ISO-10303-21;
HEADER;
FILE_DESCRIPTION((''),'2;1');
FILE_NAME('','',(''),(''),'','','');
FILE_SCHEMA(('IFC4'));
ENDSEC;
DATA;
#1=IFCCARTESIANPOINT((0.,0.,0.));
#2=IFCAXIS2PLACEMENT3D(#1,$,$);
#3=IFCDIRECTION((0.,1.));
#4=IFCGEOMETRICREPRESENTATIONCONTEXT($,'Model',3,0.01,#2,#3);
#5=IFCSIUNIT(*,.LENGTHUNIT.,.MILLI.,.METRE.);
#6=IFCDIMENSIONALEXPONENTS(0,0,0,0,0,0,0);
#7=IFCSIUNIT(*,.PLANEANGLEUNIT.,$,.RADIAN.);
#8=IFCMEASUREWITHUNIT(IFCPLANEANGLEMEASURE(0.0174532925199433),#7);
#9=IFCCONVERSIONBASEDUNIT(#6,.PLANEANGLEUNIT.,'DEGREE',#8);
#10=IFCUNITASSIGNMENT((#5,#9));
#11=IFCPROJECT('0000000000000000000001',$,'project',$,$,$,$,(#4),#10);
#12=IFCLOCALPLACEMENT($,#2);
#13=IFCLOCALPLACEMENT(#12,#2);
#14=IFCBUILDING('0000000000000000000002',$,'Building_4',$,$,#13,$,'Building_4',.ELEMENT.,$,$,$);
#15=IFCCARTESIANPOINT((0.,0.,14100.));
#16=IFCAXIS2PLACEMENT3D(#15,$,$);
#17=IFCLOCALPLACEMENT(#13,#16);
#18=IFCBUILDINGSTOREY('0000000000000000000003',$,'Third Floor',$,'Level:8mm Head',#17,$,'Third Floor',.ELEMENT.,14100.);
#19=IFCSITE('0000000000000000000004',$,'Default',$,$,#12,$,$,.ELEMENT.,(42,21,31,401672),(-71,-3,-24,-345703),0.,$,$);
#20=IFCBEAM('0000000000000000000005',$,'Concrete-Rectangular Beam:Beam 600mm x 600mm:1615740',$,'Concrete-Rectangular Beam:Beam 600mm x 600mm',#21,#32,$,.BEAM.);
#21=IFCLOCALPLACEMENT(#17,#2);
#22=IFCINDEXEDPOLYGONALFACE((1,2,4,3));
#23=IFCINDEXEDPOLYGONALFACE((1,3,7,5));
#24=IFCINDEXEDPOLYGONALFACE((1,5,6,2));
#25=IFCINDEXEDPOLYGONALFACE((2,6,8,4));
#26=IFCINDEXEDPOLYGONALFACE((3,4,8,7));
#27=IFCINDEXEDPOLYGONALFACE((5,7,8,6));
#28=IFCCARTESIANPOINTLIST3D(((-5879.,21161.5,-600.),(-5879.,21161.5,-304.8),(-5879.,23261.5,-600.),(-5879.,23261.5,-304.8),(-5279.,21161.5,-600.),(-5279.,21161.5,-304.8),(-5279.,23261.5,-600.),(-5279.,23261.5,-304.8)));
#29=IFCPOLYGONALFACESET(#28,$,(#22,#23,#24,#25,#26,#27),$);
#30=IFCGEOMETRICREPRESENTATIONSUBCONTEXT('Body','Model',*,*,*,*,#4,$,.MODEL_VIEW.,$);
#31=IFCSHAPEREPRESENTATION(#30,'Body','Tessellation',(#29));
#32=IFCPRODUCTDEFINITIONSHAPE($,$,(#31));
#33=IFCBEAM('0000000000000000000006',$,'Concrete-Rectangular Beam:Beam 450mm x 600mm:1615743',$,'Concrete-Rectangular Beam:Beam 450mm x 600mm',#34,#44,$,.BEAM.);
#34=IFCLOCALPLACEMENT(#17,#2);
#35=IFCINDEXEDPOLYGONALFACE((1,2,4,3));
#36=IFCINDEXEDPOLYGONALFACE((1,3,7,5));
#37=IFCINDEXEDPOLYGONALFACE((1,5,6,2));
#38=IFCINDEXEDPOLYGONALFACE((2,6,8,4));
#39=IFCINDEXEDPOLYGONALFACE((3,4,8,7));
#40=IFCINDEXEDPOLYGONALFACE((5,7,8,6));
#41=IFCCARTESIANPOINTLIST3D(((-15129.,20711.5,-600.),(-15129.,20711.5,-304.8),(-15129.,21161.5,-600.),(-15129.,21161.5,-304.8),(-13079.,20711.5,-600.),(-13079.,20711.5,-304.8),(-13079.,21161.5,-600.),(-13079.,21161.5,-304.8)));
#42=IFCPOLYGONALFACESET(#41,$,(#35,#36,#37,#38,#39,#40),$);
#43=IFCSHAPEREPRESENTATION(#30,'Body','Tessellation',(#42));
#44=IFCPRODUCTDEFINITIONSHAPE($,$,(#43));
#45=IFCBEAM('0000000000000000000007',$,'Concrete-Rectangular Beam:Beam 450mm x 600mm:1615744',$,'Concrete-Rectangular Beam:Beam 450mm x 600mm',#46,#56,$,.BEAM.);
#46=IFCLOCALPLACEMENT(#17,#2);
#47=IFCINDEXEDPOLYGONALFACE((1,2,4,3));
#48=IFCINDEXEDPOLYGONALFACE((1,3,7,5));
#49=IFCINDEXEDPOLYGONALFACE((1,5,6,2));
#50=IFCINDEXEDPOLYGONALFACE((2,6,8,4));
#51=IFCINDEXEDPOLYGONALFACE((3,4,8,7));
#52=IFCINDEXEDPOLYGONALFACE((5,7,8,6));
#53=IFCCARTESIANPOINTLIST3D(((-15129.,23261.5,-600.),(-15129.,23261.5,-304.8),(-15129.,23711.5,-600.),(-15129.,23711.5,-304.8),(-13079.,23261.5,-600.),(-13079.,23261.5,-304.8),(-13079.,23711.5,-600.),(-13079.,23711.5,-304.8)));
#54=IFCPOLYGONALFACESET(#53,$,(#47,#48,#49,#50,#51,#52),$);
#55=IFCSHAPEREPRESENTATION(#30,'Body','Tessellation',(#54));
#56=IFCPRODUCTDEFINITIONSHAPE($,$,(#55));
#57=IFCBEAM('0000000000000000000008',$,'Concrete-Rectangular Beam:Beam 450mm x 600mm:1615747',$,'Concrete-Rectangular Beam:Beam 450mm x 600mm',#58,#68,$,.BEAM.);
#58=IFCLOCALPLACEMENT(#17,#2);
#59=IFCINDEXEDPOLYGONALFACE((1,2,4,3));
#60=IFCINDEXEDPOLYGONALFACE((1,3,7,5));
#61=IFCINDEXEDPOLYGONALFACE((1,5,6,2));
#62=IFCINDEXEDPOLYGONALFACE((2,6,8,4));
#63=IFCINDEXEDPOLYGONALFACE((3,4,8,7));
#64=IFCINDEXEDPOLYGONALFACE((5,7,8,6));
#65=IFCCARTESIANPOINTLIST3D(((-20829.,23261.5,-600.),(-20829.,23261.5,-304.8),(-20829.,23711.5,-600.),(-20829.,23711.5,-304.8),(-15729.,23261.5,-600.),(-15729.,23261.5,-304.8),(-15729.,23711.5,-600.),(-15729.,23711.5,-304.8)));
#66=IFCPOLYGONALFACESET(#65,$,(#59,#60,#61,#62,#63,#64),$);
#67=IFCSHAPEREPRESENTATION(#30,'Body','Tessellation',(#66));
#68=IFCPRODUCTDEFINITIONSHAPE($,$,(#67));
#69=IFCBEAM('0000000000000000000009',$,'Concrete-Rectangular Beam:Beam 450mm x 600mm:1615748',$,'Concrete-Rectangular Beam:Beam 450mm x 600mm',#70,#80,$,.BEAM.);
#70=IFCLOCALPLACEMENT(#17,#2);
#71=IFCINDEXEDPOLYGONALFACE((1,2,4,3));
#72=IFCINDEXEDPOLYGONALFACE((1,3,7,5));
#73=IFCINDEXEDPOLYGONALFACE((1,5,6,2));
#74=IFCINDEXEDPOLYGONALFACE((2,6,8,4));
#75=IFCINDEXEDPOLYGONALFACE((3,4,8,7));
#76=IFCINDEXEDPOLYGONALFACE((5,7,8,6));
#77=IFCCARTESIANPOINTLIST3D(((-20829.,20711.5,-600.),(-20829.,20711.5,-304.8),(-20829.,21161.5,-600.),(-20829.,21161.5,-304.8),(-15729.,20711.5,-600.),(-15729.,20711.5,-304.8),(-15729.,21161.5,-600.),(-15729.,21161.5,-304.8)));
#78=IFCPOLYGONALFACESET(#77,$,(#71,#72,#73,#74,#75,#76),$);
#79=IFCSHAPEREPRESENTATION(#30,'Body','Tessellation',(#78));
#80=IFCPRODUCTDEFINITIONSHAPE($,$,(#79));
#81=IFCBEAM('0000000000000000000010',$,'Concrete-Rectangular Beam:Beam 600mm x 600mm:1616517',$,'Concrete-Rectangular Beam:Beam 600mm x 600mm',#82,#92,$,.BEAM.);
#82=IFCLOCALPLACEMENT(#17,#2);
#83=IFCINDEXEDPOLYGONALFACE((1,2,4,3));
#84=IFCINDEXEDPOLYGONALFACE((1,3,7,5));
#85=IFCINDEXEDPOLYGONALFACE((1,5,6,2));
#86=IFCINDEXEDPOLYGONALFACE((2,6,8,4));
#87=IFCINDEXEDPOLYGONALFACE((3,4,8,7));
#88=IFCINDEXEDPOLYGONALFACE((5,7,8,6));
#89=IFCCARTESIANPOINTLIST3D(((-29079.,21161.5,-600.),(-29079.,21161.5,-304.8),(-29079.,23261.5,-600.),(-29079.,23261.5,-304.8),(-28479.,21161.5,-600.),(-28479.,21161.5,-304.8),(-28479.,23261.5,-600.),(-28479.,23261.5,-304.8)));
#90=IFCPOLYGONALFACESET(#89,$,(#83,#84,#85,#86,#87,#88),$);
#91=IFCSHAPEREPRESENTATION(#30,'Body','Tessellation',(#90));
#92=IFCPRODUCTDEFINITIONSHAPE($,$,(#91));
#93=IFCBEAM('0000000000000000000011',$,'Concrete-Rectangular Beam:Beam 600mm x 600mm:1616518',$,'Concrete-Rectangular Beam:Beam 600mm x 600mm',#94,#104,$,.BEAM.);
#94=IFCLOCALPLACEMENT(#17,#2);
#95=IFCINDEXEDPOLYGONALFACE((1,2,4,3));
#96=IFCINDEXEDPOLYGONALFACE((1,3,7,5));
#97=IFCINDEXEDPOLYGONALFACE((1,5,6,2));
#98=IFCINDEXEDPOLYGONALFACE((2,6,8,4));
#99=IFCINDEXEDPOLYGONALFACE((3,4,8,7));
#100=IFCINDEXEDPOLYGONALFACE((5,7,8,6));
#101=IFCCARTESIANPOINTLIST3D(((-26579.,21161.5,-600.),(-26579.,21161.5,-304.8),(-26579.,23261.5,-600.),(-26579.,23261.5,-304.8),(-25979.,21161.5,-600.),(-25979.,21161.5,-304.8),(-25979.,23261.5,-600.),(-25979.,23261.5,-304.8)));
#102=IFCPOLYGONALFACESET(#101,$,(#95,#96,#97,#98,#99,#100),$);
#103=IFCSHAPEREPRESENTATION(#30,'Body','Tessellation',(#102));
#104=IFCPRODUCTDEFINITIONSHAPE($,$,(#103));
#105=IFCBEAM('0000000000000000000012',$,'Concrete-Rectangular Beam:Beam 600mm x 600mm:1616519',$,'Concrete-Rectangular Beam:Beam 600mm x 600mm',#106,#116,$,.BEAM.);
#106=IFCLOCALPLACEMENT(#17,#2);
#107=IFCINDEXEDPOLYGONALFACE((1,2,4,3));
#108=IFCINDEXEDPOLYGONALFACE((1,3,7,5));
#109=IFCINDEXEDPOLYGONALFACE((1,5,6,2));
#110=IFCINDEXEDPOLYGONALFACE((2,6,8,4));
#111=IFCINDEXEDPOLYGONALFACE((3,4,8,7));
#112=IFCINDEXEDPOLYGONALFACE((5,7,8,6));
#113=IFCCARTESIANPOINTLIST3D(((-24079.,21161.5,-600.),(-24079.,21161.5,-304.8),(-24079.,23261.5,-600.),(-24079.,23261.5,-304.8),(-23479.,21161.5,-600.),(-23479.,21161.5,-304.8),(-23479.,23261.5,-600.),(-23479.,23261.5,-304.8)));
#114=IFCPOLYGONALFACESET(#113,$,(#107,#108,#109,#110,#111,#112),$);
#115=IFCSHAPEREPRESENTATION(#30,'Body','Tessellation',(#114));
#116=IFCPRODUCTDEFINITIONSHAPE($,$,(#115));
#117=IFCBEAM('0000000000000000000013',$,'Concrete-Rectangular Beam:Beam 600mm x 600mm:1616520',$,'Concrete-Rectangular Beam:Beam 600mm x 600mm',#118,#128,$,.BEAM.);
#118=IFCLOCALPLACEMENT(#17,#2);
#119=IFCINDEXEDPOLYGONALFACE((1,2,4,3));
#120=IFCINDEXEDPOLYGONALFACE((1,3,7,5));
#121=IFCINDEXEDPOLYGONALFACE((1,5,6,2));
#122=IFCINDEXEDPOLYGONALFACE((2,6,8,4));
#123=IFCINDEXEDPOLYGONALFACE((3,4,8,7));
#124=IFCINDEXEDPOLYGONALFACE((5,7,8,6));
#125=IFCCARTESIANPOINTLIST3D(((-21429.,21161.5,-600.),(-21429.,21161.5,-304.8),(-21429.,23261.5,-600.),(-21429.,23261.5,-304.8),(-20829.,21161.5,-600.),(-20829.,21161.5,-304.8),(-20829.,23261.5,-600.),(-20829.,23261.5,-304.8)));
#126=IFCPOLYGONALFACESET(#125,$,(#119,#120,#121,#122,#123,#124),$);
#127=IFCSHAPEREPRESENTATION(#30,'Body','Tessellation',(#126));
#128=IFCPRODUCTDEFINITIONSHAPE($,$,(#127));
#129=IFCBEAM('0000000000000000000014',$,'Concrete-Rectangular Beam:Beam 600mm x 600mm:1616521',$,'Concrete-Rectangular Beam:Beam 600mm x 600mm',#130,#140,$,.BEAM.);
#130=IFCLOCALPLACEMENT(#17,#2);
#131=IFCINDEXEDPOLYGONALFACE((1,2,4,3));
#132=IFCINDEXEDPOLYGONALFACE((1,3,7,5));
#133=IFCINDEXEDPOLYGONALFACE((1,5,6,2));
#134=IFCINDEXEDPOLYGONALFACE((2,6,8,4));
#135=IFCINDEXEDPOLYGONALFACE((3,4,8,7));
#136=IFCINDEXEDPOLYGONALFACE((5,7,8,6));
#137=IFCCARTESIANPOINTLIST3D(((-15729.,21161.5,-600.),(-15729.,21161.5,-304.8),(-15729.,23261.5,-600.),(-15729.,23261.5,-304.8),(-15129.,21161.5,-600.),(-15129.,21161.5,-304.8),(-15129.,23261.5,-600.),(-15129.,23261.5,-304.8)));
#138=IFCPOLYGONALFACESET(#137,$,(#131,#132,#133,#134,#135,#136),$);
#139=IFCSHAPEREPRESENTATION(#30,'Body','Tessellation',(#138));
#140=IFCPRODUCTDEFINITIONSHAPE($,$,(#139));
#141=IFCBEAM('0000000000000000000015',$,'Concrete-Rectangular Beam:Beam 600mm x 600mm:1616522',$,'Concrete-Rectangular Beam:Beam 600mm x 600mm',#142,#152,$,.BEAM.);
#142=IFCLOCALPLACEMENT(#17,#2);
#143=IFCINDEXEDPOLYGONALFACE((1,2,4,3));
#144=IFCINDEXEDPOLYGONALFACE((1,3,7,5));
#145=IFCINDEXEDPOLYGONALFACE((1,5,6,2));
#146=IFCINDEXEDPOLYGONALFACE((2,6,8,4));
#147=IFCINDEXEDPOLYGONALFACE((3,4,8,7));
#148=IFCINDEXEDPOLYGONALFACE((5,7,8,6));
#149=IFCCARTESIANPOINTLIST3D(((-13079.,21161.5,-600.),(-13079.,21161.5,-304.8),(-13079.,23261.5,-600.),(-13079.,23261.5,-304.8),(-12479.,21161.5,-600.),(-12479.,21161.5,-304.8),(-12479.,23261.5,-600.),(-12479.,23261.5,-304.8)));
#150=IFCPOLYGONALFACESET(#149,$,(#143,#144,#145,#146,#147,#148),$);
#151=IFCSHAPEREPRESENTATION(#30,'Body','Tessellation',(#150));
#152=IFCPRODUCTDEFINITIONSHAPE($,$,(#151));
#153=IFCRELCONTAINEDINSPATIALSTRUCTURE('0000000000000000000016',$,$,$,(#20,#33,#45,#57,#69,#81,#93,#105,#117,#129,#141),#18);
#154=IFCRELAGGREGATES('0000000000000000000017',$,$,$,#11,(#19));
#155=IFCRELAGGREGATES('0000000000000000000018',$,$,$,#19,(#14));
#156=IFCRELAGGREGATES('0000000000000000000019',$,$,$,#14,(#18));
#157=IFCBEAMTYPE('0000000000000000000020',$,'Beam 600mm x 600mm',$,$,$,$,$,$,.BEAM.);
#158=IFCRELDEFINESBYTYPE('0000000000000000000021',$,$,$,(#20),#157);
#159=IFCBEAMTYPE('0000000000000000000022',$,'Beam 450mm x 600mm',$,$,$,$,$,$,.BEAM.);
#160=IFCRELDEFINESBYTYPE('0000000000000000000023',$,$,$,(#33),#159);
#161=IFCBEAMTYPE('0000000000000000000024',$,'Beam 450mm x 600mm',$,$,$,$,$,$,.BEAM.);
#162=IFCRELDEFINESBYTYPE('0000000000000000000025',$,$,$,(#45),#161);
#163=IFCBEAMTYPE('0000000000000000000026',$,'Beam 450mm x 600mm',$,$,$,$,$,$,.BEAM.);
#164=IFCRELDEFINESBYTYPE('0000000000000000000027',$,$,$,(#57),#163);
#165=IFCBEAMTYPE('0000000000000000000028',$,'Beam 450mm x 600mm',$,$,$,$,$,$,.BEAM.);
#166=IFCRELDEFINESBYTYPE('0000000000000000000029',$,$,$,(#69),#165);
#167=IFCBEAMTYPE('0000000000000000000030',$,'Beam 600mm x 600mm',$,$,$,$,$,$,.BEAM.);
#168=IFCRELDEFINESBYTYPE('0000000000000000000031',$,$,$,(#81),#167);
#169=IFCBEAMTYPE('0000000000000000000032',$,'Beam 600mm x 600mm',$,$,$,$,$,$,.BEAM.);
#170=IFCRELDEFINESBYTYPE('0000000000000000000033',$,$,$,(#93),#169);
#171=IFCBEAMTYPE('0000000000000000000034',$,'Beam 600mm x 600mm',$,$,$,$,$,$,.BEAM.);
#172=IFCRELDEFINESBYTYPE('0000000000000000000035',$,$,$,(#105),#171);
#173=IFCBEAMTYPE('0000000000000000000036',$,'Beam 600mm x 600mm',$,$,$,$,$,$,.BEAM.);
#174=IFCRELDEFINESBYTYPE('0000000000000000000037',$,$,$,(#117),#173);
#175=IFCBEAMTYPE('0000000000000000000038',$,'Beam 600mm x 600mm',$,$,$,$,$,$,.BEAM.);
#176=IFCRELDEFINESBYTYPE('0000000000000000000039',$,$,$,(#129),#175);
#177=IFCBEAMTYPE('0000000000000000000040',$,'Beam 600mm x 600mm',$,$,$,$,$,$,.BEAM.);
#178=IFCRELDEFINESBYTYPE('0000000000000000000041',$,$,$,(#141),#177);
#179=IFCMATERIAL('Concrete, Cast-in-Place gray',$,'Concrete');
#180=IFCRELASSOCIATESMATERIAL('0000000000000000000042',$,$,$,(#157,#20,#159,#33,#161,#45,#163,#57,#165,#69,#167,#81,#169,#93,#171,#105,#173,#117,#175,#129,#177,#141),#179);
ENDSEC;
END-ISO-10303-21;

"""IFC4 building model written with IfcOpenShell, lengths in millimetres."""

from ifc_helpers import new_model, entity, si_unit, converted_unit, direction, frame, origin, place, context, subcontext, project, spatial, indexed_curve, outline, extrude, source, transform, mapped, material, type_object, type_shapes, element, save


model = new_model("IFC4")

# Units and contexts
model_context = context("Model", 3, precision=0.01, world=origin(), true_north=direction((0.0, 1.0)))
body_context = subcontext(model_context, "Body", "Model", "MODEL_VIEW")
ifc_project = project(units=[si_unit("LENGTHUNIT", "METRE", prefix="MILLI"), converted_unit("PLANEANGLEUNIT", "DEGREE", entity("IfcPlaneAngleMeasure", 0.0174532925199433), si_unit("PLANEANGLEUNIT", "RADIAN"), dimensions=[0, 0, 0, 0, 0, 0, 0])], contexts=[model_context])

# Site, building, storey
site_placement = place(None, origin())
site = spatial("IfcSite", under=ifc_project, at=site_placement, Name="Default", CompositionType="ELEMENT", RefLatitude=(42, 21, 31, 401672), RefLongitude=(-71, -3, -24, -345703), RefElevation=0.0)
building_placement = place(site_placement, origin())
building = spatial("IfcBuilding", under=site, at=building_placement, Name="Building_4", LongName="Building_4", CompositionType="ELEMENT")
storey_placement = place(building_placement, frame((0.0, 0.0, 14100.0)))
storey = spatial("IfcBuildingStorey", under=building, at=storey_placement, Name="Third Floor", ObjectType="Level:8mm Head", LongName="Third Floor", CompositionType="ELEMENT", Elevation=14100.0)

# Beams
ifc_material_1 = material(Name="Concrete, Cast-in-Place gray", Category="Concrete")
beam_type_1 = type_object("IfcBeamType", Name="Beam 600mm x 600mm", PredefinedType="BEAM", material=ifc_material_1)
shared_shape_1 = source(origin(), body_context, "Body", "SweptSolid", [
    extrude(outline(indexed_curve([(-300.0, -147.6), (300.0, -147.6), (300.0, 147.6), (-300.0, 147.6), (-300.0, -147.6)], self_intersect=False)), frame((-5579.0, 23261.5, 13647.6), z_axis=(0.0, -1.0, 0.0), x_axis=(-1.0, 0.0, 0.0)), (0.0, 0.0, 1.0), 2100.0),
])
type_shapes(beam_type_1, [shared_shape_1])
beam_1_placement = place(storey_placement, frame((0.0, 0.0, -14100.0)))
element("IfcBeam", 1, at=beam_1_placement, inside=storey, type_object=beam_type_1, material=ifc_material_1, Name="Concrete-Rectangular Beam:Beam 600mm x 600mm:1615740", ObjectType="Concrete-Rectangular Beam:Beam 600mm x 600mm", PredefinedType="BEAM", context=body_context, shape_type="MappedRepresentation", body=[
    mapped(shared_shape_1, transform((0.0, 0.0, 0.0), scale=1.0)),
])
beam_type_2 = type_object("IfcBeamType", Name="Beam 450mm x 600mm", PredefinedType="BEAM", material=ifc_material_1)
shared_shape_2 = source(origin(), body_context, "Body", "SweptSolid", [
    extrude(outline(indexed_curve([(-147.6, -225.0), (147.6, -225.0), (147.6, 225.0), (-147.6, 225.0), (-147.6, -225.0)], self_intersect=False)), frame((-15129.0, 20936.5, 13647.6), z_axis=(1.0, 0.0, 0.0), x_axis=(0.0, 0.0, -1.0)), (0.0, 0.0, 1.0), 2050.0),
])
type_shapes(beam_type_2, [shared_shape_2])
beam_2_placement = place(storey_placement, frame((0.0, 0.0, -14100.0)))
element("IfcBeam", 2, at=beam_2_placement, inside=storey, type_object=beam_type_2, material=ifc_material_1, Name="Concrete-Rectangular Beam:Beam 450mm x 600mm:1615743", ObjectType="Concrete-Rectangular Beam:Beam 450mm x 600mm", PredefinedType="BEAM", context=body_context, shape_type="MappedRepresentation", body=[
    mapped(shared_shape_2, transform((0.0, 0.0, 0.0), scale=1.0)),
])
beam_type_3 = type_object("IfcBeamType", Name="Beam 450mm x 600mm", PredefinedType="BEAM", material=ifc_material_1)
shared_shape_3 = source(origin(), body_context, "Body", "SweptSolid", [
    extrude(outline(indexed_curve([(-147.6, -225.0), (147.6, -225.0), (147.6, 225.0), (-147.6, 225.0), (-147.6, -225.0)], self_intersect=False)), frame((-15129.0, 23486.5, 13647.6), z_axis=(1.0, 0.0, 0.0), x_axis=(0.0, 0.0, -1.0)), (0.0, 0.0, 1.0), 2050.0),
])
type_shapes(beam_type_3, [shared_shape_3])
beam_3_placement = place(storey_placement, frame((0.0, 0.0, -14100.0)))
element("IfcBeam", 3, at=beam_3_placement, inside=storey, type_object=beam_type_3, material=ifc_material_1, Name="Concrete-Rectangular Beam:Beam 450mm x 600mm:1615744", ObjectType="Concrete-Rectangular Beam:Beam 450mm x 600mm", PredefinedType="BEAM", context=body_context, shape_type="MappedRepresentation", body=[
    mapped(shared_shape_3, transform((0.0, 0.0, 0.0), scale=1.0)),
])
beam_type_4 = type_object("IfcBeamType", Name="Beam 450mm x 600mm", PredefinedType="BEAM", material=ifc_material_1)
shared_shape_4 = source(origin(), body_context, "Body", "SweptSolid", [
    extrude(outline(indexed_curve([(-147.6, -225.0), (147.6, -225.0), (147.6, 225.0), (-147.6, 225.0), (-147.6, -225.0)], self_intersect=False)), frame((-20829.0, 23486.5, 13647.6), z_axis=(1.0, 0.0, 0.0), x_axis=(0.0, 0.0, -1.0)), (0.0, 0.0, 1.0), 5100.0),
])
type_shapes(beam_type_4, [shared_shape_4])
beam_4_placement = place(storey_placement, frame((0.0, 0.0, -14100.0)))
element("IfcBeam", 4, at=beam_4_placement, inside=storey, type_object=beam_type_4, material=ifc_material_1, Name="Concrete-Rectangular Beam:Beam 450mm x 600mm:1615747", ObjectType="Concrete-Rectangular Beam:Beam 450mm x 600mm", PredefinedType="BEAM", context=body_context, shape_type="MappedRepresentation", body=[
    mapped(shared_shape_4, transform((0.0, 0.0, 0.0), scale=1.0)),
])
beam_type_5 = type_object("IfcBeamType", Name="Beam 450mm x 600mm", PredefinedType="BEAM", material=ifc_material_1)
shared_shape_5 = source(origin(), body_context, "Body", "SweptSolid", [
    extrude(outline(indexed_curve([(-147.6, -225.0), (147.6, -225.0), (147.6, 225.0), (-147.6, 225.0), (-147.6, -225.0)], self_intersect=False)), frame((-15729.0, 20936.5, 13647.6), z_axis=(-1.0, 0.0, 0.0), x_axis=(0.0, 0.0, -1.0)), (0.0, 0.0, 1.0), 5100.0),
])
type_shapes(beam_type_5, [shared_shape_5])
beam_5_placement = place(storey_placement, frame((0.0, 0.0, -14100.0)))
element("IfcBeam", 5, at=beam_5_placement, inside=storey, type_object=beam_type_5, material=ifc_material_1, Name="Concrete-Rectangular Beam:Beam 450mm x 600mm:1615748", ObjectType="Concrete-Rectangular Beam:Beam 450mm x 600mm", PredefinedType="BEAM", context=body_context, shape_type="MappedRepresentation", body=[
    mapped(shared_shape_5, transform((0.0, 0.0, 0.0), scale=1.0)),
])
beam_type_6 = type_object("IfcBeamType", Name="Beam 600mm x 600mm", PredefinedType="BEAM", material=ifc_material_1)
shared_shape_6 = source(origin(), body_context, "Body", "SweptSolid", [
    extrude(outline(indexed_curve([(-300.0, -147.6), (300.0, -147.6), (300.0, 147.6), (-300.0, 147.6), (-300.0, -147.6)], self_intersect=False)), frame((-28779.0, 23261.5, 13647.6), z_axis=(0.0, -1.0, 0.0), x_axis=(-1.0, 0.0, 0.0)), (0.0, 0.0, 1.0), 2100.0),
])
type_shapes(beam_type_6, [shared_shape_6])
beam_6_placement = place(storey_placement, frame((0.0, 0.0, -14100.0)))
element("IfcBeam", 6, at=beam_6_placement, inside=storey, type_object=beam_type_6, material=ifc_material_1, Name="Concrete-Rectangular Beam:Beam 600mm x 600mm:1616517", ObjectType="Concrete-Rectangular Beam:Beam 600mm x 600mm", PredefinedType="BEAM", context=body_context, shape_type="MappedRepresentation", body=[
    mapped(shared_shape_6, transform((0.0, 0.0, 0.0), scale=1.0)),
])
beam_type_7 = type_object("IfcBeamType", Name="Beam 600mm x 600mm", PredefinedType="BEAM", material=ifc_material_1)
shared_shape_7 = source(origin(), body_context, "Body", "SweptSolid", [
    extrude(outline(indexed_curve([(-300.0, -147.6), (300.0, -147.6), (300.0, 147.6), (-300.0, 147.6), (-300.0, -147.6)], self_intersect=False)), frame((-26279.0, 23261.5, 13647.6), z_axis=(0.0, -1.0, 0.0), x_axis=(-1.0, 0.0, 0.0)), (0.0, 0.0, 1.0), 2100.0),
])
type_shapes(beam_type_7, [shared_shape_7])
beam_7_placement = place(storey_placement, frame((0.0, 0.0, -14100.0)))
element("IfcBeam", 7, at=beam_7_placement, inside=storey, type_object=beam_type_7, material=ifc_material_1, Name="Concrete-Rectangular Beam:Beam 600mm x 600mm:1616518", ObjectType="Concrete-Rectangular Beam:Beam 600mm x 600mm", PredefinedType="BEAM", context=body_context, shape_type="MappedRepresentation", body=[
    mapped(shared_shape_7, transform((0.0, 0.0, 0.0), scale=1.0)),
])
beam_type_8 = type_object("IfcBeamType", Name="Beam 600mm x 600mm", PredefinedType="BEAM", material=ifc_material_1)
shared_shape_8 = source(origin(), body_context, "Body", "SweptSolid", [
    extrude(outline(indexed_curve([(-300.0, -147.6), (300.0, -147.6), (300.0, 147.6), (-300.0, 147.6), (-300.0, -147.6)], self_intersect=False)), frame((-23779.0, 23261.5, 13647.6), z_axis=(0.0, -1.0, 0.0), x_axis=(-1.0, 0.0, 0.0)), (0.0, 0.0, 1.0), 2100.0),
])
type_shapes(beam_type_8, [shared_shape_8])
beam_8_placement = place(storey_placement, frame((0.0, 0.0, -14100.0)))
element("IfcBeam", 8, at=beam_8_placement, inside=storey, type_object=beam_type_8, material=ifc_material_1, Name="Concrete-Rectangular Beam:Beam 600mm x 600mm:1616519", ObjectType="Concrete-Rectangular Beam:Beam 600mm x 600mm", PredefinedType="BEAM", context=body_context, shape_type="MappedRepresentation", body=[
    mapped(shared_shape_8, transform((0.0, 0.0, 0.0), scale=1.0)),
])
beam_type_9 = type_object("IfcBeamType", Name="Beam 600mm x 600mm", PredefinedType="BEAM", material=ifc_material_1)
shared_shape_9 = source(origin(), body_context, "Body", "SweptSolid", [
    extrude(outline(indexed_curve([(-300.0, -147.6), (300.0, -147.6), (300.0, 147.6), (-300.0, 147.6), (-300.0, -147.6)], self_intersect=False)), frame((-21129.0, 23261.5, 13647.6), z_axis=(0.0, -1.0, 0.0), x_axis=(-1.0, 0.0, 0.0)), (0.0, 0.0, 1.0), 2100.0),
])
type_shapes(beam_type_9, [shared_shape_9])
beam_9_placement = place(storey_placement, frame((0.0, 0.0, -14100.0)))
element("IfcBeam", 9, at=beam_9_placement, inside=storey, type_object=beam_type_9, material=ifc_material_1, Name="Concrete-Rectangular Beam:Beam 600mm x 600mm:1616520", ObjectType="Concrete-Rectangular Beam:Beam 600mm x 600mm", PredefinedType="BEAM", context=body_context, shape_type="MappedRepresentation", body=[
    mapped(shared_shape_9, transform((0.0, 0.0, 0.0), scale=1.0)),
])
beam_type_10 = type_object("IfcBeamType", Name="Beam 600mm x 600mm", PredefinedType="BEAM", material=ifc_material_1)
shared_shape_10 = source(origin(), body_context, "Body", "SweptSolid", [
    extrude(outline(indexed_curve([(-300.0, -147.6), (300.0, -147.6), (300.0, 147.6), (-300.0, 147.6), (-300.0, -147.6)], self_intersect=False)), frame((-15429.0, 23261.5, 13647.6), z_axis=(0.0, -1.0, 0.0), x_axis=(-1.0, 0.0, 0.0)), (0.0, 0.0, 1.0), 2100.0),
])
type_shapes(beam_type_10, [shared_shape_10])
beam_10_placement = place(storey_placement, frame((0.0, 0.0, -14100.0)))
element("IfcBeam", 10, at=beam_10_placement, inside=storey, type_object=beam_type_10, material=ifc_material_1, Name="Concrete-Rectangular Beam:Beam 600mm x 600mm:1616521", ObjectType="Concrete-Rectangular Beam:Beam 600mm x 600mm", PredefinedType="BEAM", context=body_context, shape_type="MappedRepresentation", body=[
    mapped(shared_shape_10, transform((0.0, 0.0, 0.0), scale=1.0)),
])
beam_type_11 = type_object("IfcBeamType", Name="Beam 600mm x 600mm", PredefinedType="BEAM", material=ifc_material_1)
shared_shape_11 = source(origin(), body_context, "Body", "SweptSolid", [
    extrude(outline(indexed_curve([(-300.0, -147.6), (300.0, -147.6), (300.0, 147.6), (-300.0, 147.6), (-300.0, -147.6)], self_intersect=False)), frame((-12779.0, 23261.5, 13647.6), z_axis=(0.0, -1.0, 0.0), x_axis=(-1.0, 0.0, 0.0)), (0.0, 0.0, 1.0), 2100.0),
])
type_shapes(beam_type_11, [shared_shape_11])
beam_11_placement = place(storey_placement, frame((0.0, 0.0, -14100.0)))
element("IfcBeam", 11, at=beam_11_placement, inside=storey, type_object=beam_type_11, material=ifc_material_1, Name="Concrete-Rectangular Beam:Beam 600mm x 600mm:1616522", ObjectType="Concrete-Rectangular Beam:Beam 600mm x 600mm", PredefinedType="BEAM", context=body_context, shape_type="MappedRepresentation", body=[
    mapped(shared_shape_11, transform((0.0, 0.0, 0.0), scale=1.0)),
])

save(model, "model.ifc")
